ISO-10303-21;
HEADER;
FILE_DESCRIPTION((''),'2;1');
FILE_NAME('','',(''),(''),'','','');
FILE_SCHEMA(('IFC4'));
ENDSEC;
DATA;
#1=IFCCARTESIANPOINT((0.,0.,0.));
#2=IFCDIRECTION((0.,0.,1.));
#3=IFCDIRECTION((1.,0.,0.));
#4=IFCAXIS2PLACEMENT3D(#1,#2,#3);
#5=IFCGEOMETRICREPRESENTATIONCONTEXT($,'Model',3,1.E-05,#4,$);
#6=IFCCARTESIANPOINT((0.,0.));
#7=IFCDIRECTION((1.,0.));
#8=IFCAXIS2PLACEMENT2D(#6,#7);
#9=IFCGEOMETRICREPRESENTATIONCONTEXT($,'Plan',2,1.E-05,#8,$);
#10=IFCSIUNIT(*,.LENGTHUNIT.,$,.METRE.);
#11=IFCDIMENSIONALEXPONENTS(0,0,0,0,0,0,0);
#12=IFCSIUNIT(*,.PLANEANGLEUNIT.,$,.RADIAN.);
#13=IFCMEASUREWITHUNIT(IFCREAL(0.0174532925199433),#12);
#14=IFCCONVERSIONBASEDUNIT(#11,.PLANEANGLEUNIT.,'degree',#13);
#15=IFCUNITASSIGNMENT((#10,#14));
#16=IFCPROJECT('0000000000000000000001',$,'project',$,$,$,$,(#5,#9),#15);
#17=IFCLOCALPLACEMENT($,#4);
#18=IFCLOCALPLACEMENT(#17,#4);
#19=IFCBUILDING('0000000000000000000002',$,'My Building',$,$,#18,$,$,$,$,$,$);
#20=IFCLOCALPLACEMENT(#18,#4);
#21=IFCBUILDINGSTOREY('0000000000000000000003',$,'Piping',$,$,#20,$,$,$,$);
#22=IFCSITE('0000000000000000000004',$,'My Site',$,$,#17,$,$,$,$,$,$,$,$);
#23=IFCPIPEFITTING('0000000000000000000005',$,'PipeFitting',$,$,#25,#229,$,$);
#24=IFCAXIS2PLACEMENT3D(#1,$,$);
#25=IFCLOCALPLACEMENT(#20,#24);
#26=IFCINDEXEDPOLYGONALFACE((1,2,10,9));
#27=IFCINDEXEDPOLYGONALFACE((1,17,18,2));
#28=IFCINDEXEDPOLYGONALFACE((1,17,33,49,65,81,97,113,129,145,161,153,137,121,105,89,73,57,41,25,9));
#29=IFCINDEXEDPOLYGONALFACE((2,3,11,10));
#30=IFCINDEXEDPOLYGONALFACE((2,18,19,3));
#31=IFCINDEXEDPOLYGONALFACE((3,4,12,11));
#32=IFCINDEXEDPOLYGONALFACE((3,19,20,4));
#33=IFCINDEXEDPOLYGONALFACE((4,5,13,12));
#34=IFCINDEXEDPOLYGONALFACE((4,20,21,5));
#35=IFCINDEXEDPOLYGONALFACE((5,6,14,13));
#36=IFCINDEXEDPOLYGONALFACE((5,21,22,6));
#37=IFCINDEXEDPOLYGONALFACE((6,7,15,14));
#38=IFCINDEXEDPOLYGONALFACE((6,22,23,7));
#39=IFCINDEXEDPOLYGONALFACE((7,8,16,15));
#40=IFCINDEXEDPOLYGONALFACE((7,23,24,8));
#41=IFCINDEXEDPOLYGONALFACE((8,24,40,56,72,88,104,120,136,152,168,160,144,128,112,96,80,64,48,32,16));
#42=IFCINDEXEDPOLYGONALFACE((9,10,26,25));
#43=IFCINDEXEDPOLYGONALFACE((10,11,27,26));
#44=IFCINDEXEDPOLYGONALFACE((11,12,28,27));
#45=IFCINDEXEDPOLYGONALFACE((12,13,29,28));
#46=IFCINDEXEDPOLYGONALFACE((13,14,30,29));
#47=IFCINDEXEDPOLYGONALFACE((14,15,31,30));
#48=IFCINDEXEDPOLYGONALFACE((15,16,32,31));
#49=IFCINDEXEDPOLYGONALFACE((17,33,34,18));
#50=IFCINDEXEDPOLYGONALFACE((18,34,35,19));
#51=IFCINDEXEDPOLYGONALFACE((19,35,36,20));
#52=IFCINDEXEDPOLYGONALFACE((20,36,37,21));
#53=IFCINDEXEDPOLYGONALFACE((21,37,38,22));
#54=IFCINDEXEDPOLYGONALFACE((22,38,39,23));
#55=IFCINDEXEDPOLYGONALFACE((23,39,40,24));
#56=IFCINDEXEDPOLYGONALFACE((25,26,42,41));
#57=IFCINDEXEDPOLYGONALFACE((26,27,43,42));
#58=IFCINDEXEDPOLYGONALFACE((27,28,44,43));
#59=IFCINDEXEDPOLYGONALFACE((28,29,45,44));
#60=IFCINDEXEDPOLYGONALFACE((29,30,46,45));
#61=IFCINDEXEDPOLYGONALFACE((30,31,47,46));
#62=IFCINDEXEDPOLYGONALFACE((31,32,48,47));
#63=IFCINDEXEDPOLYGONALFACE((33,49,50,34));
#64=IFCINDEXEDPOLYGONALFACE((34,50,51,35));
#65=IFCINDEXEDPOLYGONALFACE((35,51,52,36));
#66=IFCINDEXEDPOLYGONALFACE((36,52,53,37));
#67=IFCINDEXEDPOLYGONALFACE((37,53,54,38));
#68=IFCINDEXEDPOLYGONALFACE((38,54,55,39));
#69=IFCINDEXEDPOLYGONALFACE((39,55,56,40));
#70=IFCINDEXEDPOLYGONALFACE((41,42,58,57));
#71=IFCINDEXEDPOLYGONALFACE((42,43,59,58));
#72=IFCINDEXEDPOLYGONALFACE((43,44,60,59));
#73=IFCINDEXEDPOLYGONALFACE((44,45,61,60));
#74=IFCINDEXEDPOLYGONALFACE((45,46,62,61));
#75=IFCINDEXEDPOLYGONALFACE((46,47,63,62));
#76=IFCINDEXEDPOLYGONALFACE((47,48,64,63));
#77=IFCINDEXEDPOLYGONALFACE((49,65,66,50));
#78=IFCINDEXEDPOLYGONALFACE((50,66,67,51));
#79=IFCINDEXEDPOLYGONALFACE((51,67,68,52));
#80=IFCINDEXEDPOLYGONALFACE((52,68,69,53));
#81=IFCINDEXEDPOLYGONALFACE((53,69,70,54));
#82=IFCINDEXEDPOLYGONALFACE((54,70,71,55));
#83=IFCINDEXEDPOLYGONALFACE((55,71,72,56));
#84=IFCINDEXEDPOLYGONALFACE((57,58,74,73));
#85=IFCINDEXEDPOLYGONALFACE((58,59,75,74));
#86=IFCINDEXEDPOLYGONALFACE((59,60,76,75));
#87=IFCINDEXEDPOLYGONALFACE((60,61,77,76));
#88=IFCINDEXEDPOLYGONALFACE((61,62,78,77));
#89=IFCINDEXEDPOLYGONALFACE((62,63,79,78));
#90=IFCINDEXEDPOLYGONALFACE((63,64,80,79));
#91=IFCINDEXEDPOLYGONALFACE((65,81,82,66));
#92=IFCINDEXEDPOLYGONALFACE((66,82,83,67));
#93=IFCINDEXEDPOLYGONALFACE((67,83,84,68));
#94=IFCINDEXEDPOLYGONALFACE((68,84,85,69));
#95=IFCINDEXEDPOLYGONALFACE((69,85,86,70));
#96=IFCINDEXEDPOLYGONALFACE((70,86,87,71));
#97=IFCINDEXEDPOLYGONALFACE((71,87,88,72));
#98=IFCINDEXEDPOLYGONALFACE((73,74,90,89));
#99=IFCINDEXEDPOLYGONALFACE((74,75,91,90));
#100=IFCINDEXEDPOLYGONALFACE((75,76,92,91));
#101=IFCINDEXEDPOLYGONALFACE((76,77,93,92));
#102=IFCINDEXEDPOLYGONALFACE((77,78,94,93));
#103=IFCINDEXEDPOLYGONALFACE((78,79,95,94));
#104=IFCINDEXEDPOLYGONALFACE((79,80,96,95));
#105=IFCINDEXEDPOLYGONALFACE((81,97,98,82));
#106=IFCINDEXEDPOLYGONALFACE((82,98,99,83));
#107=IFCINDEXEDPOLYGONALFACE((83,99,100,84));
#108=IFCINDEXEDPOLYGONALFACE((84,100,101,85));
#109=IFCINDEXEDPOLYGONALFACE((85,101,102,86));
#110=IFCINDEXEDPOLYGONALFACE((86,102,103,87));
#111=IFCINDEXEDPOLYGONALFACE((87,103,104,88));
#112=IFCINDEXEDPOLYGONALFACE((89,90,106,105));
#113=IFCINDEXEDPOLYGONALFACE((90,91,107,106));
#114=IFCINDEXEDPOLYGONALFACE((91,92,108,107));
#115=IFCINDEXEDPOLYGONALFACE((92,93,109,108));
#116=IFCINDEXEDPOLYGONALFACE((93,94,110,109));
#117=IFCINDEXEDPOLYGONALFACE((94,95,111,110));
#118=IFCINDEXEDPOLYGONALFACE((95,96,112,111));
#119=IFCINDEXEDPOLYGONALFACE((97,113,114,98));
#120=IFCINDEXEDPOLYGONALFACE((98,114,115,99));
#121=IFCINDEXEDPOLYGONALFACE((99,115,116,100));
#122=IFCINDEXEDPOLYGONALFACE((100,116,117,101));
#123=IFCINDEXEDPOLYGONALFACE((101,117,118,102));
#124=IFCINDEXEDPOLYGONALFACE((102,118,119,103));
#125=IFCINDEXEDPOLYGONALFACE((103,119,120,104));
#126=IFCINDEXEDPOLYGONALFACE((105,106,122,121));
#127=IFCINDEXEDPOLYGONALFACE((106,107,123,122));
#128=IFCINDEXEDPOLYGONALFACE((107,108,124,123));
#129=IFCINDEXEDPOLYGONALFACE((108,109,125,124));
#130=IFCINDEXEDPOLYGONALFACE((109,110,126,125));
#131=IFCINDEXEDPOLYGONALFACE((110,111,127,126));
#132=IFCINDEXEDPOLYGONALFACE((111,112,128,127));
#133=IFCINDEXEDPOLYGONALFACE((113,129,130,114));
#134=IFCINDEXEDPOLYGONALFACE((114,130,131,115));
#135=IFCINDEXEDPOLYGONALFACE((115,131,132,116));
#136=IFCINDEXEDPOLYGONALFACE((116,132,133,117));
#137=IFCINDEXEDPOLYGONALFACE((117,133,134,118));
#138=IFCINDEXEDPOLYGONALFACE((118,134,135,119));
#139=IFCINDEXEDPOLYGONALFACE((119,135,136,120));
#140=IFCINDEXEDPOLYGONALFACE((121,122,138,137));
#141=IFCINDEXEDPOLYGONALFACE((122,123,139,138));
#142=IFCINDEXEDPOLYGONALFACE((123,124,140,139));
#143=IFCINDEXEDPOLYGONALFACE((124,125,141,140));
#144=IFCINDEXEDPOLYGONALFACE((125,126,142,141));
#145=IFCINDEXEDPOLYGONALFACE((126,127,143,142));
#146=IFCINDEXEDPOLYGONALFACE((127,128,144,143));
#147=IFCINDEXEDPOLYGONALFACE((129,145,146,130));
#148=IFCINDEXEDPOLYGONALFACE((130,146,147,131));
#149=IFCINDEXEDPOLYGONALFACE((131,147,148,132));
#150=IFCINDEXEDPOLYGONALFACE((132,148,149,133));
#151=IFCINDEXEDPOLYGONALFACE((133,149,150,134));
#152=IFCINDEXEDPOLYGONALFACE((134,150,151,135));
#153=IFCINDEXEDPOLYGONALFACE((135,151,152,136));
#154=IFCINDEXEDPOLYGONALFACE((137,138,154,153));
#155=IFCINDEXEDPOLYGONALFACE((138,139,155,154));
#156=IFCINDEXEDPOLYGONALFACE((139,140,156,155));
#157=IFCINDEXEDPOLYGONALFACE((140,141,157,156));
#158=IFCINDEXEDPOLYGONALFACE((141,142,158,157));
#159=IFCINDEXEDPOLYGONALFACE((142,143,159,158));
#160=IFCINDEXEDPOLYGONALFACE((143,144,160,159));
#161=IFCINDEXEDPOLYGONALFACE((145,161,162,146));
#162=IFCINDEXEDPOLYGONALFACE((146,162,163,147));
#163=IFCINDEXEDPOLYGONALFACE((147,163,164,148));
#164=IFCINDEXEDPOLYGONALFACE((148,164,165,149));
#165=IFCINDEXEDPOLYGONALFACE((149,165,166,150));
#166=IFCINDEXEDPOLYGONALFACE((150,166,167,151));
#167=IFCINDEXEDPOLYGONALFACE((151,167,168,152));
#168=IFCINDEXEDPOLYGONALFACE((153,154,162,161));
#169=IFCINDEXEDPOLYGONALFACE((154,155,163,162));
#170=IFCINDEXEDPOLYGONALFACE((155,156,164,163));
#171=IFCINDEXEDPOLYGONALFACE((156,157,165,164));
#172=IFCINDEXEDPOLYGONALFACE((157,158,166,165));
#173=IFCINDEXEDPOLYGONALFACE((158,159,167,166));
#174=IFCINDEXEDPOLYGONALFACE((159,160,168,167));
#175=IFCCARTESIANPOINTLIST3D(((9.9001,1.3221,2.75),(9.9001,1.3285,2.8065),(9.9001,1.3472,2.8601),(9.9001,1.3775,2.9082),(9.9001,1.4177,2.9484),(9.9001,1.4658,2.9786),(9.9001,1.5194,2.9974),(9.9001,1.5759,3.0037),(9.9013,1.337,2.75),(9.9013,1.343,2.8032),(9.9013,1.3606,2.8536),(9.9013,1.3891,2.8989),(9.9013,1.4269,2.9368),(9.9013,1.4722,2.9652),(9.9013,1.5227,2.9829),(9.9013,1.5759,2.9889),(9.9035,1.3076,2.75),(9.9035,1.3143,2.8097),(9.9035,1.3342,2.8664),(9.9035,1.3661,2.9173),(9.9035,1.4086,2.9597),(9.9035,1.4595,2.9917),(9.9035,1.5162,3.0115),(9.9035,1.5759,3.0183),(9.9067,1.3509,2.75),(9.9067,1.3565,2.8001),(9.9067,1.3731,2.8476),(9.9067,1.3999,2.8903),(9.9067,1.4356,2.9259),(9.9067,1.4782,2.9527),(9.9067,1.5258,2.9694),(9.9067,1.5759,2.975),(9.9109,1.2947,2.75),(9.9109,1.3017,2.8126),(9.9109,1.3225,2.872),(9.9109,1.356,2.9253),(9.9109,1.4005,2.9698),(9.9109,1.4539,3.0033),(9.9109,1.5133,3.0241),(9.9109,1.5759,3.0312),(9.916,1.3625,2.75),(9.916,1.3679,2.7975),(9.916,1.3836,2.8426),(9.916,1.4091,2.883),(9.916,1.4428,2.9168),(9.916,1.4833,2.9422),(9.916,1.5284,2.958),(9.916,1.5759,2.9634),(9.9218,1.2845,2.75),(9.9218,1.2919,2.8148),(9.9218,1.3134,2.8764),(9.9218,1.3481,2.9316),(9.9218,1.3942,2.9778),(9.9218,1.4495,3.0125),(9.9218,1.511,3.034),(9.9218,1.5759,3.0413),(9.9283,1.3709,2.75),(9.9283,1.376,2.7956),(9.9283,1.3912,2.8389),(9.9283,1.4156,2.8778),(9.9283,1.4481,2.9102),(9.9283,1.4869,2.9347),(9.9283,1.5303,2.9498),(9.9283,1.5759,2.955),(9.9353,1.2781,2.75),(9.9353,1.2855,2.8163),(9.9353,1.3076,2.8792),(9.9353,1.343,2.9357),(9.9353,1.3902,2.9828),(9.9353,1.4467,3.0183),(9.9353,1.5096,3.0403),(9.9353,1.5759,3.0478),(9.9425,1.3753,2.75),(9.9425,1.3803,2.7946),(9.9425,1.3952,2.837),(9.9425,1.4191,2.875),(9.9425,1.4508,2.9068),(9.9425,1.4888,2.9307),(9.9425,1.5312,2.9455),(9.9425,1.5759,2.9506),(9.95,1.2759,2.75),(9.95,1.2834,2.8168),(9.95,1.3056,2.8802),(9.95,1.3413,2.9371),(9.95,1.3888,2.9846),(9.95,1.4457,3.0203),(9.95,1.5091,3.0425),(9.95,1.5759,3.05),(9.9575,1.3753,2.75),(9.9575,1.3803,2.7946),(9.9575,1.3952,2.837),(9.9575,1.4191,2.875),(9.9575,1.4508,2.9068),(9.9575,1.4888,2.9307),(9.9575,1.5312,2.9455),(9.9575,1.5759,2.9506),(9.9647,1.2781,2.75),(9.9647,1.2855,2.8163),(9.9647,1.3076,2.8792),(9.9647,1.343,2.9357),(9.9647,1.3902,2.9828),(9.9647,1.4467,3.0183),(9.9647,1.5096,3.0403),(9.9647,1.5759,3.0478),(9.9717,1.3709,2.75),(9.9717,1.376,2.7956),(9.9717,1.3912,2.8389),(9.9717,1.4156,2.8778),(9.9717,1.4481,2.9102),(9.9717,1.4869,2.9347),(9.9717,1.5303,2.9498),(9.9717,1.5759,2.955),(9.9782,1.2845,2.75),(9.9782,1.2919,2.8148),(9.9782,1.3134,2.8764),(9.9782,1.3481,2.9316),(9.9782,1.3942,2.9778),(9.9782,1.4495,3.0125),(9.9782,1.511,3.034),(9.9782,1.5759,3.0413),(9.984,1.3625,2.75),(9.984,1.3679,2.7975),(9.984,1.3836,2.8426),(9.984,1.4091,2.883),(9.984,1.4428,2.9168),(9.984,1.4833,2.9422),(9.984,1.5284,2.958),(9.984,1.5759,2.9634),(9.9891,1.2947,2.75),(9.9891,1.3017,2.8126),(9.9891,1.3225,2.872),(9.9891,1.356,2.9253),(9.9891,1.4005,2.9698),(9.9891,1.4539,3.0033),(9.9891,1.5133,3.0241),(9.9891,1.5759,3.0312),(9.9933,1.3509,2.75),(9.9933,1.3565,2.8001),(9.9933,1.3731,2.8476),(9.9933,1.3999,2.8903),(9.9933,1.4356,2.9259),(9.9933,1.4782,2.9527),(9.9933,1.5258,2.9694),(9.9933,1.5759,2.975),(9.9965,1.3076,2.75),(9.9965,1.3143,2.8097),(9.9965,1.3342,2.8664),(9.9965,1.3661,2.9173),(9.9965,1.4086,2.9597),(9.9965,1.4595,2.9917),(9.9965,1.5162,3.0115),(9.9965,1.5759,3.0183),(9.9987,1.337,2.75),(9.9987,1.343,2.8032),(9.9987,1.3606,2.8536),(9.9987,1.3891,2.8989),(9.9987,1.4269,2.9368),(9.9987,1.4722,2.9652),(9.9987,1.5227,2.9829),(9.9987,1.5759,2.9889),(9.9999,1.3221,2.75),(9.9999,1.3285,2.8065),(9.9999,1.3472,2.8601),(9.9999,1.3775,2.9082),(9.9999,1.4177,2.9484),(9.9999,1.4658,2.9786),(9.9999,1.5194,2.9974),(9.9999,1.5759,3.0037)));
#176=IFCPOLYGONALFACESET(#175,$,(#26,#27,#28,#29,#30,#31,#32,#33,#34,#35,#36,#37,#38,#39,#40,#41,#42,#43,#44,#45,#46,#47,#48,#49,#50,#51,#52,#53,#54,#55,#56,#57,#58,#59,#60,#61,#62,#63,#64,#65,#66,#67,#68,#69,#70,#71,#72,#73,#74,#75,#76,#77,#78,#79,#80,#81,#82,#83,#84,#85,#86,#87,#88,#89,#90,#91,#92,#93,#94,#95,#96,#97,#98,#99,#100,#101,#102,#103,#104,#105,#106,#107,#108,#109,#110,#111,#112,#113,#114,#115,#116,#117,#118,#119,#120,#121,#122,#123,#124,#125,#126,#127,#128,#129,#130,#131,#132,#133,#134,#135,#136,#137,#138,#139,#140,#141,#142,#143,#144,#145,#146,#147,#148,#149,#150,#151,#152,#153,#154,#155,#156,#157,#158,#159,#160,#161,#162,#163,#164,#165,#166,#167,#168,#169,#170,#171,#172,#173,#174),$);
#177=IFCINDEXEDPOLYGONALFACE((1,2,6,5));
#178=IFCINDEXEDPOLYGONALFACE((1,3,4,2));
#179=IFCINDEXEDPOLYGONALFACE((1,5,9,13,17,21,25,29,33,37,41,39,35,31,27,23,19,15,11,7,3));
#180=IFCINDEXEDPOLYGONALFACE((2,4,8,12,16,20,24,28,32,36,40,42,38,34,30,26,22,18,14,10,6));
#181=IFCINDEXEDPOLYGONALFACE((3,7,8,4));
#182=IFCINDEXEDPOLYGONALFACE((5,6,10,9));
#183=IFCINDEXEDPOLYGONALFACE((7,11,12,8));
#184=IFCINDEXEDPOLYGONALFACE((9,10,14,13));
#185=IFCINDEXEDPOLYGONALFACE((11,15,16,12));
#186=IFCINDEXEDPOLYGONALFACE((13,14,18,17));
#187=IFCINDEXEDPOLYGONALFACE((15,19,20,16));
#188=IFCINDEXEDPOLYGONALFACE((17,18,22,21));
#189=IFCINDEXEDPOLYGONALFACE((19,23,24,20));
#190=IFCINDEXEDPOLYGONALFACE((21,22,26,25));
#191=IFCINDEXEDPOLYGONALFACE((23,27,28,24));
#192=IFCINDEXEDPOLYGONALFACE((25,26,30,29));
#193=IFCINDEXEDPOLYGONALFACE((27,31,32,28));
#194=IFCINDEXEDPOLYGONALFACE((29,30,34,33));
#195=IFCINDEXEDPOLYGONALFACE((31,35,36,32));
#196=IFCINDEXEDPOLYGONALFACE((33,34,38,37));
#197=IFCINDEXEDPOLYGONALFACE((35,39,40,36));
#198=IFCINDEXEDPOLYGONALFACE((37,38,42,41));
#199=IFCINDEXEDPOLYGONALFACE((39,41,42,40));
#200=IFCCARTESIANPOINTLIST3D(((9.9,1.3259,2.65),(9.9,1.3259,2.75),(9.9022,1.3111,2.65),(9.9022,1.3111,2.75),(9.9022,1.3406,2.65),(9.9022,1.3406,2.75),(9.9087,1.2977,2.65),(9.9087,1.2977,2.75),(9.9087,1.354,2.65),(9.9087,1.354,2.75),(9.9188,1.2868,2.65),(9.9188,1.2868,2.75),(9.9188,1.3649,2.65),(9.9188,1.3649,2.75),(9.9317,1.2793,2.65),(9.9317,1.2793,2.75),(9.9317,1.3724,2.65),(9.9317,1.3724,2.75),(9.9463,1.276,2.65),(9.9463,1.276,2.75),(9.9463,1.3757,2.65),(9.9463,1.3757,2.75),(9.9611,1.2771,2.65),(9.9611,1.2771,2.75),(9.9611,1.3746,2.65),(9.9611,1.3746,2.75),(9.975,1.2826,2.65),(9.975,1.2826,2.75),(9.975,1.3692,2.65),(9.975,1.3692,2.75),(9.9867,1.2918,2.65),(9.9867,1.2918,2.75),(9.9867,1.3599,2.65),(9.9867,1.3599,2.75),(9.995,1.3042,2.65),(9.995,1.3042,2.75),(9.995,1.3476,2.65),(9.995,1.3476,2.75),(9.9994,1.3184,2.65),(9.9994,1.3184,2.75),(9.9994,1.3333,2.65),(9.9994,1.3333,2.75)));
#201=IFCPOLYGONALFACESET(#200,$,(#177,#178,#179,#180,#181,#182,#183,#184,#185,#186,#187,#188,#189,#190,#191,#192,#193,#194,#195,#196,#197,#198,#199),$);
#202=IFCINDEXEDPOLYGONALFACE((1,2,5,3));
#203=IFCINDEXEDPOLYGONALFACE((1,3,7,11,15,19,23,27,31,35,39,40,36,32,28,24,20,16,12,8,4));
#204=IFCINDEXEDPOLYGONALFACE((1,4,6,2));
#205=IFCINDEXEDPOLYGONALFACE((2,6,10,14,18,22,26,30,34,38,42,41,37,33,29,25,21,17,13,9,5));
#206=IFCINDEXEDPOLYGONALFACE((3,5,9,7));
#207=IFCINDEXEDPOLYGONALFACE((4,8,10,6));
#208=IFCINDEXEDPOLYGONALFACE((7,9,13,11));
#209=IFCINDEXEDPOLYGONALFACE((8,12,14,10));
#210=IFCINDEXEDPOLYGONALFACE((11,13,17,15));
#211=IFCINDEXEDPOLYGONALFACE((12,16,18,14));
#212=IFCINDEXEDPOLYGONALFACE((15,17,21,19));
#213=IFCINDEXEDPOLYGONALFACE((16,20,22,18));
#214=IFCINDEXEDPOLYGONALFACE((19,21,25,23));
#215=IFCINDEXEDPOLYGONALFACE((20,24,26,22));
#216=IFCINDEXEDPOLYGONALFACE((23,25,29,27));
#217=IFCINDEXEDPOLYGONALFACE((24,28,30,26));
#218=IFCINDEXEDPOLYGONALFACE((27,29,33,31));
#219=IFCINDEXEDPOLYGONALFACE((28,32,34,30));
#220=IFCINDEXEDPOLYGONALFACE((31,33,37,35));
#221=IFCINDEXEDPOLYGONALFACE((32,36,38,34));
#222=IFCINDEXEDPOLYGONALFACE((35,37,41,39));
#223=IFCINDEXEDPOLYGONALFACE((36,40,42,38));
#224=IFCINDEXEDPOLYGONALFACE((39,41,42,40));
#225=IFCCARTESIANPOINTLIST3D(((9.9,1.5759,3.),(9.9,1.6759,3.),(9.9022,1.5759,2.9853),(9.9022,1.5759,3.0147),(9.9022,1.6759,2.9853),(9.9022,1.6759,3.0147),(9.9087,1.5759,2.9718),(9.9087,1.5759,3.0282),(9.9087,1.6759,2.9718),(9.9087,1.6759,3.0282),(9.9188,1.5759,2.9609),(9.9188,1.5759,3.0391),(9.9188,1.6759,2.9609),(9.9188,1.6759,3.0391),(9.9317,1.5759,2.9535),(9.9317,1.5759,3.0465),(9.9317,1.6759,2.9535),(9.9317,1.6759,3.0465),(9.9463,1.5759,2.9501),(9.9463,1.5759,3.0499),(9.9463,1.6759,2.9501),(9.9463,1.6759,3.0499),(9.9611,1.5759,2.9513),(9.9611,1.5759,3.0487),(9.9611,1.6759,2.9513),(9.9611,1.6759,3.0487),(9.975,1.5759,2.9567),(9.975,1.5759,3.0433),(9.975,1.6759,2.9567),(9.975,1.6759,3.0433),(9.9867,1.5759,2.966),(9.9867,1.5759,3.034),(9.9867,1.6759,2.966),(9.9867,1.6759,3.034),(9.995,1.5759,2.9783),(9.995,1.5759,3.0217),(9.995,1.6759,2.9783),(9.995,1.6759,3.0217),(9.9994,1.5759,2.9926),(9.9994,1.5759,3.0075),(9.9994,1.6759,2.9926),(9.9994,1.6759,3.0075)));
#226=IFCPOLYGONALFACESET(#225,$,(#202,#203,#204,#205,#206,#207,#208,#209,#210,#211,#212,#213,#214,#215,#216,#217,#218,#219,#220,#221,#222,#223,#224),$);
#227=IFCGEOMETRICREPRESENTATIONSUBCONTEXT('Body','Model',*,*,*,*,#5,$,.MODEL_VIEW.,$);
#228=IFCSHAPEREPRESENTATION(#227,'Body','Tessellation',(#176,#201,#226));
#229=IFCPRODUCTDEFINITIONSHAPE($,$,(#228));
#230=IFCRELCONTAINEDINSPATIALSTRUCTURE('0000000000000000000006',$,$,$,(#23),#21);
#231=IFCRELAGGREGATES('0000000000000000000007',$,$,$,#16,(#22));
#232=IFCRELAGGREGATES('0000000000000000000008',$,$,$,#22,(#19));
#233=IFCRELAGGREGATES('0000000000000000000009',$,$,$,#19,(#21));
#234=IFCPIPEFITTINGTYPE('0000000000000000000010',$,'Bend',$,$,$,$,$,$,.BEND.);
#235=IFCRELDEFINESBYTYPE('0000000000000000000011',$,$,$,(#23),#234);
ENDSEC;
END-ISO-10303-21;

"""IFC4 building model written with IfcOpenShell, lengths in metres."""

from ifc_helpers import new_model, entity, si_unit, converted_unit, frame, origin_with_axes, origin_2d_with_axis, place, context, subcontext, project, spatial, circle, extrude, source, transform, mapped, type_object, type_shapes, element, save


model = new_model("IFC4")

# Units and contexts
model_context = context("Model", 3, precision=1e-05, world=origin_with_axes())
plan_context = context("Plan", 2, precision=1e-05, world=origin_2d_with_axis())
body_context = subcontext(model_context, "Body", "Model", "MODEL_VIEW")
ifc_project = project(units=[si_unit("LENGTHUNIT", "METRE"), converted_unit("PLANEANGLEUNIT", "degree", entity("IfcReal", 0.0174532925199433), si_unit("PLANEANGLEUNIT", "RADIAN"), dimensions=[0, 0, 0, 0, 0, 0, 0])], contexts=[model_context, plan_context])

# Site, building, storey
site_placement = place(None, origin_with_axes())
site = spatial("IfcSite", under=ifc_project, at=site_placement, Name="My Site")
building_placement = place(site_placement, origin_with_axes())
building = spatial("IfcBuilding", under=site, at=building_placement, Name="My Building")
storey_placement = place(building_placement, origin_with_axes())
storey = spatial("IfcBuildingStorey", under=building, at=storey_placement, Name="Piping")

# Pipe fitting
pipe_fitting_type = type_object("IfcPipeFittingType", Name="Bend", PredefinedType="BEND")
shared_shape = source(origin_with_axes(), body_context, "Body", "SolidModel", [
    entity("IfcSweptDiskSolid", entity("IfcIndexedPolyCurve", entity("IfcCartesianPointList3D", [[0.0, 0.0, -0.1], [0.0, 0.0732, -0.2768], [0.0, 0.25, -0.35]]), [entity("IfcArcIndex", [1, 2, 3])]), 0.05),
    extrude(circle(Radius=0.05), origin_with_axes(), (0.0, 0.0, -1.0), 0.1),
    extrude(circle(Radius=0.05), frame((0.0, 0.25, -0.35), z_axis=(0.0, 1.0, 0.0), x_axis=(1.0, 0.0, 0.0)), (0.0, 0.0, 1.0), 0.1),
])
type_shapes(pipe_fitting_type, [shared_shape])
for number, where, z_axis, x_axis, name in (
    (1, (9.95, 1.3259, 2.65), (0.0, 0.0, -1.0), (-1.0, 0.0, 0.0), "PipeFitting"),
):
    element("IfcPipeFitting", number, at=place(storey_placement, frame(where, z_axis=z_axis, x_axis=x_axis)), inside=storey, type_object=pipe_fitting_type, Name=name, context=body_context, shape_type="MappedRepresentation", body=[
        mapped(shared_shape, transform((0.0, 0.0, 0.0), x_axis=(1.0, 0.0, 0.0), y_axis=(0.0, 1.0, 0.0), z_axis=(0.0, 0.0, 1.0), scale=1.0)),
    ])

save(model, "model.ifc")
